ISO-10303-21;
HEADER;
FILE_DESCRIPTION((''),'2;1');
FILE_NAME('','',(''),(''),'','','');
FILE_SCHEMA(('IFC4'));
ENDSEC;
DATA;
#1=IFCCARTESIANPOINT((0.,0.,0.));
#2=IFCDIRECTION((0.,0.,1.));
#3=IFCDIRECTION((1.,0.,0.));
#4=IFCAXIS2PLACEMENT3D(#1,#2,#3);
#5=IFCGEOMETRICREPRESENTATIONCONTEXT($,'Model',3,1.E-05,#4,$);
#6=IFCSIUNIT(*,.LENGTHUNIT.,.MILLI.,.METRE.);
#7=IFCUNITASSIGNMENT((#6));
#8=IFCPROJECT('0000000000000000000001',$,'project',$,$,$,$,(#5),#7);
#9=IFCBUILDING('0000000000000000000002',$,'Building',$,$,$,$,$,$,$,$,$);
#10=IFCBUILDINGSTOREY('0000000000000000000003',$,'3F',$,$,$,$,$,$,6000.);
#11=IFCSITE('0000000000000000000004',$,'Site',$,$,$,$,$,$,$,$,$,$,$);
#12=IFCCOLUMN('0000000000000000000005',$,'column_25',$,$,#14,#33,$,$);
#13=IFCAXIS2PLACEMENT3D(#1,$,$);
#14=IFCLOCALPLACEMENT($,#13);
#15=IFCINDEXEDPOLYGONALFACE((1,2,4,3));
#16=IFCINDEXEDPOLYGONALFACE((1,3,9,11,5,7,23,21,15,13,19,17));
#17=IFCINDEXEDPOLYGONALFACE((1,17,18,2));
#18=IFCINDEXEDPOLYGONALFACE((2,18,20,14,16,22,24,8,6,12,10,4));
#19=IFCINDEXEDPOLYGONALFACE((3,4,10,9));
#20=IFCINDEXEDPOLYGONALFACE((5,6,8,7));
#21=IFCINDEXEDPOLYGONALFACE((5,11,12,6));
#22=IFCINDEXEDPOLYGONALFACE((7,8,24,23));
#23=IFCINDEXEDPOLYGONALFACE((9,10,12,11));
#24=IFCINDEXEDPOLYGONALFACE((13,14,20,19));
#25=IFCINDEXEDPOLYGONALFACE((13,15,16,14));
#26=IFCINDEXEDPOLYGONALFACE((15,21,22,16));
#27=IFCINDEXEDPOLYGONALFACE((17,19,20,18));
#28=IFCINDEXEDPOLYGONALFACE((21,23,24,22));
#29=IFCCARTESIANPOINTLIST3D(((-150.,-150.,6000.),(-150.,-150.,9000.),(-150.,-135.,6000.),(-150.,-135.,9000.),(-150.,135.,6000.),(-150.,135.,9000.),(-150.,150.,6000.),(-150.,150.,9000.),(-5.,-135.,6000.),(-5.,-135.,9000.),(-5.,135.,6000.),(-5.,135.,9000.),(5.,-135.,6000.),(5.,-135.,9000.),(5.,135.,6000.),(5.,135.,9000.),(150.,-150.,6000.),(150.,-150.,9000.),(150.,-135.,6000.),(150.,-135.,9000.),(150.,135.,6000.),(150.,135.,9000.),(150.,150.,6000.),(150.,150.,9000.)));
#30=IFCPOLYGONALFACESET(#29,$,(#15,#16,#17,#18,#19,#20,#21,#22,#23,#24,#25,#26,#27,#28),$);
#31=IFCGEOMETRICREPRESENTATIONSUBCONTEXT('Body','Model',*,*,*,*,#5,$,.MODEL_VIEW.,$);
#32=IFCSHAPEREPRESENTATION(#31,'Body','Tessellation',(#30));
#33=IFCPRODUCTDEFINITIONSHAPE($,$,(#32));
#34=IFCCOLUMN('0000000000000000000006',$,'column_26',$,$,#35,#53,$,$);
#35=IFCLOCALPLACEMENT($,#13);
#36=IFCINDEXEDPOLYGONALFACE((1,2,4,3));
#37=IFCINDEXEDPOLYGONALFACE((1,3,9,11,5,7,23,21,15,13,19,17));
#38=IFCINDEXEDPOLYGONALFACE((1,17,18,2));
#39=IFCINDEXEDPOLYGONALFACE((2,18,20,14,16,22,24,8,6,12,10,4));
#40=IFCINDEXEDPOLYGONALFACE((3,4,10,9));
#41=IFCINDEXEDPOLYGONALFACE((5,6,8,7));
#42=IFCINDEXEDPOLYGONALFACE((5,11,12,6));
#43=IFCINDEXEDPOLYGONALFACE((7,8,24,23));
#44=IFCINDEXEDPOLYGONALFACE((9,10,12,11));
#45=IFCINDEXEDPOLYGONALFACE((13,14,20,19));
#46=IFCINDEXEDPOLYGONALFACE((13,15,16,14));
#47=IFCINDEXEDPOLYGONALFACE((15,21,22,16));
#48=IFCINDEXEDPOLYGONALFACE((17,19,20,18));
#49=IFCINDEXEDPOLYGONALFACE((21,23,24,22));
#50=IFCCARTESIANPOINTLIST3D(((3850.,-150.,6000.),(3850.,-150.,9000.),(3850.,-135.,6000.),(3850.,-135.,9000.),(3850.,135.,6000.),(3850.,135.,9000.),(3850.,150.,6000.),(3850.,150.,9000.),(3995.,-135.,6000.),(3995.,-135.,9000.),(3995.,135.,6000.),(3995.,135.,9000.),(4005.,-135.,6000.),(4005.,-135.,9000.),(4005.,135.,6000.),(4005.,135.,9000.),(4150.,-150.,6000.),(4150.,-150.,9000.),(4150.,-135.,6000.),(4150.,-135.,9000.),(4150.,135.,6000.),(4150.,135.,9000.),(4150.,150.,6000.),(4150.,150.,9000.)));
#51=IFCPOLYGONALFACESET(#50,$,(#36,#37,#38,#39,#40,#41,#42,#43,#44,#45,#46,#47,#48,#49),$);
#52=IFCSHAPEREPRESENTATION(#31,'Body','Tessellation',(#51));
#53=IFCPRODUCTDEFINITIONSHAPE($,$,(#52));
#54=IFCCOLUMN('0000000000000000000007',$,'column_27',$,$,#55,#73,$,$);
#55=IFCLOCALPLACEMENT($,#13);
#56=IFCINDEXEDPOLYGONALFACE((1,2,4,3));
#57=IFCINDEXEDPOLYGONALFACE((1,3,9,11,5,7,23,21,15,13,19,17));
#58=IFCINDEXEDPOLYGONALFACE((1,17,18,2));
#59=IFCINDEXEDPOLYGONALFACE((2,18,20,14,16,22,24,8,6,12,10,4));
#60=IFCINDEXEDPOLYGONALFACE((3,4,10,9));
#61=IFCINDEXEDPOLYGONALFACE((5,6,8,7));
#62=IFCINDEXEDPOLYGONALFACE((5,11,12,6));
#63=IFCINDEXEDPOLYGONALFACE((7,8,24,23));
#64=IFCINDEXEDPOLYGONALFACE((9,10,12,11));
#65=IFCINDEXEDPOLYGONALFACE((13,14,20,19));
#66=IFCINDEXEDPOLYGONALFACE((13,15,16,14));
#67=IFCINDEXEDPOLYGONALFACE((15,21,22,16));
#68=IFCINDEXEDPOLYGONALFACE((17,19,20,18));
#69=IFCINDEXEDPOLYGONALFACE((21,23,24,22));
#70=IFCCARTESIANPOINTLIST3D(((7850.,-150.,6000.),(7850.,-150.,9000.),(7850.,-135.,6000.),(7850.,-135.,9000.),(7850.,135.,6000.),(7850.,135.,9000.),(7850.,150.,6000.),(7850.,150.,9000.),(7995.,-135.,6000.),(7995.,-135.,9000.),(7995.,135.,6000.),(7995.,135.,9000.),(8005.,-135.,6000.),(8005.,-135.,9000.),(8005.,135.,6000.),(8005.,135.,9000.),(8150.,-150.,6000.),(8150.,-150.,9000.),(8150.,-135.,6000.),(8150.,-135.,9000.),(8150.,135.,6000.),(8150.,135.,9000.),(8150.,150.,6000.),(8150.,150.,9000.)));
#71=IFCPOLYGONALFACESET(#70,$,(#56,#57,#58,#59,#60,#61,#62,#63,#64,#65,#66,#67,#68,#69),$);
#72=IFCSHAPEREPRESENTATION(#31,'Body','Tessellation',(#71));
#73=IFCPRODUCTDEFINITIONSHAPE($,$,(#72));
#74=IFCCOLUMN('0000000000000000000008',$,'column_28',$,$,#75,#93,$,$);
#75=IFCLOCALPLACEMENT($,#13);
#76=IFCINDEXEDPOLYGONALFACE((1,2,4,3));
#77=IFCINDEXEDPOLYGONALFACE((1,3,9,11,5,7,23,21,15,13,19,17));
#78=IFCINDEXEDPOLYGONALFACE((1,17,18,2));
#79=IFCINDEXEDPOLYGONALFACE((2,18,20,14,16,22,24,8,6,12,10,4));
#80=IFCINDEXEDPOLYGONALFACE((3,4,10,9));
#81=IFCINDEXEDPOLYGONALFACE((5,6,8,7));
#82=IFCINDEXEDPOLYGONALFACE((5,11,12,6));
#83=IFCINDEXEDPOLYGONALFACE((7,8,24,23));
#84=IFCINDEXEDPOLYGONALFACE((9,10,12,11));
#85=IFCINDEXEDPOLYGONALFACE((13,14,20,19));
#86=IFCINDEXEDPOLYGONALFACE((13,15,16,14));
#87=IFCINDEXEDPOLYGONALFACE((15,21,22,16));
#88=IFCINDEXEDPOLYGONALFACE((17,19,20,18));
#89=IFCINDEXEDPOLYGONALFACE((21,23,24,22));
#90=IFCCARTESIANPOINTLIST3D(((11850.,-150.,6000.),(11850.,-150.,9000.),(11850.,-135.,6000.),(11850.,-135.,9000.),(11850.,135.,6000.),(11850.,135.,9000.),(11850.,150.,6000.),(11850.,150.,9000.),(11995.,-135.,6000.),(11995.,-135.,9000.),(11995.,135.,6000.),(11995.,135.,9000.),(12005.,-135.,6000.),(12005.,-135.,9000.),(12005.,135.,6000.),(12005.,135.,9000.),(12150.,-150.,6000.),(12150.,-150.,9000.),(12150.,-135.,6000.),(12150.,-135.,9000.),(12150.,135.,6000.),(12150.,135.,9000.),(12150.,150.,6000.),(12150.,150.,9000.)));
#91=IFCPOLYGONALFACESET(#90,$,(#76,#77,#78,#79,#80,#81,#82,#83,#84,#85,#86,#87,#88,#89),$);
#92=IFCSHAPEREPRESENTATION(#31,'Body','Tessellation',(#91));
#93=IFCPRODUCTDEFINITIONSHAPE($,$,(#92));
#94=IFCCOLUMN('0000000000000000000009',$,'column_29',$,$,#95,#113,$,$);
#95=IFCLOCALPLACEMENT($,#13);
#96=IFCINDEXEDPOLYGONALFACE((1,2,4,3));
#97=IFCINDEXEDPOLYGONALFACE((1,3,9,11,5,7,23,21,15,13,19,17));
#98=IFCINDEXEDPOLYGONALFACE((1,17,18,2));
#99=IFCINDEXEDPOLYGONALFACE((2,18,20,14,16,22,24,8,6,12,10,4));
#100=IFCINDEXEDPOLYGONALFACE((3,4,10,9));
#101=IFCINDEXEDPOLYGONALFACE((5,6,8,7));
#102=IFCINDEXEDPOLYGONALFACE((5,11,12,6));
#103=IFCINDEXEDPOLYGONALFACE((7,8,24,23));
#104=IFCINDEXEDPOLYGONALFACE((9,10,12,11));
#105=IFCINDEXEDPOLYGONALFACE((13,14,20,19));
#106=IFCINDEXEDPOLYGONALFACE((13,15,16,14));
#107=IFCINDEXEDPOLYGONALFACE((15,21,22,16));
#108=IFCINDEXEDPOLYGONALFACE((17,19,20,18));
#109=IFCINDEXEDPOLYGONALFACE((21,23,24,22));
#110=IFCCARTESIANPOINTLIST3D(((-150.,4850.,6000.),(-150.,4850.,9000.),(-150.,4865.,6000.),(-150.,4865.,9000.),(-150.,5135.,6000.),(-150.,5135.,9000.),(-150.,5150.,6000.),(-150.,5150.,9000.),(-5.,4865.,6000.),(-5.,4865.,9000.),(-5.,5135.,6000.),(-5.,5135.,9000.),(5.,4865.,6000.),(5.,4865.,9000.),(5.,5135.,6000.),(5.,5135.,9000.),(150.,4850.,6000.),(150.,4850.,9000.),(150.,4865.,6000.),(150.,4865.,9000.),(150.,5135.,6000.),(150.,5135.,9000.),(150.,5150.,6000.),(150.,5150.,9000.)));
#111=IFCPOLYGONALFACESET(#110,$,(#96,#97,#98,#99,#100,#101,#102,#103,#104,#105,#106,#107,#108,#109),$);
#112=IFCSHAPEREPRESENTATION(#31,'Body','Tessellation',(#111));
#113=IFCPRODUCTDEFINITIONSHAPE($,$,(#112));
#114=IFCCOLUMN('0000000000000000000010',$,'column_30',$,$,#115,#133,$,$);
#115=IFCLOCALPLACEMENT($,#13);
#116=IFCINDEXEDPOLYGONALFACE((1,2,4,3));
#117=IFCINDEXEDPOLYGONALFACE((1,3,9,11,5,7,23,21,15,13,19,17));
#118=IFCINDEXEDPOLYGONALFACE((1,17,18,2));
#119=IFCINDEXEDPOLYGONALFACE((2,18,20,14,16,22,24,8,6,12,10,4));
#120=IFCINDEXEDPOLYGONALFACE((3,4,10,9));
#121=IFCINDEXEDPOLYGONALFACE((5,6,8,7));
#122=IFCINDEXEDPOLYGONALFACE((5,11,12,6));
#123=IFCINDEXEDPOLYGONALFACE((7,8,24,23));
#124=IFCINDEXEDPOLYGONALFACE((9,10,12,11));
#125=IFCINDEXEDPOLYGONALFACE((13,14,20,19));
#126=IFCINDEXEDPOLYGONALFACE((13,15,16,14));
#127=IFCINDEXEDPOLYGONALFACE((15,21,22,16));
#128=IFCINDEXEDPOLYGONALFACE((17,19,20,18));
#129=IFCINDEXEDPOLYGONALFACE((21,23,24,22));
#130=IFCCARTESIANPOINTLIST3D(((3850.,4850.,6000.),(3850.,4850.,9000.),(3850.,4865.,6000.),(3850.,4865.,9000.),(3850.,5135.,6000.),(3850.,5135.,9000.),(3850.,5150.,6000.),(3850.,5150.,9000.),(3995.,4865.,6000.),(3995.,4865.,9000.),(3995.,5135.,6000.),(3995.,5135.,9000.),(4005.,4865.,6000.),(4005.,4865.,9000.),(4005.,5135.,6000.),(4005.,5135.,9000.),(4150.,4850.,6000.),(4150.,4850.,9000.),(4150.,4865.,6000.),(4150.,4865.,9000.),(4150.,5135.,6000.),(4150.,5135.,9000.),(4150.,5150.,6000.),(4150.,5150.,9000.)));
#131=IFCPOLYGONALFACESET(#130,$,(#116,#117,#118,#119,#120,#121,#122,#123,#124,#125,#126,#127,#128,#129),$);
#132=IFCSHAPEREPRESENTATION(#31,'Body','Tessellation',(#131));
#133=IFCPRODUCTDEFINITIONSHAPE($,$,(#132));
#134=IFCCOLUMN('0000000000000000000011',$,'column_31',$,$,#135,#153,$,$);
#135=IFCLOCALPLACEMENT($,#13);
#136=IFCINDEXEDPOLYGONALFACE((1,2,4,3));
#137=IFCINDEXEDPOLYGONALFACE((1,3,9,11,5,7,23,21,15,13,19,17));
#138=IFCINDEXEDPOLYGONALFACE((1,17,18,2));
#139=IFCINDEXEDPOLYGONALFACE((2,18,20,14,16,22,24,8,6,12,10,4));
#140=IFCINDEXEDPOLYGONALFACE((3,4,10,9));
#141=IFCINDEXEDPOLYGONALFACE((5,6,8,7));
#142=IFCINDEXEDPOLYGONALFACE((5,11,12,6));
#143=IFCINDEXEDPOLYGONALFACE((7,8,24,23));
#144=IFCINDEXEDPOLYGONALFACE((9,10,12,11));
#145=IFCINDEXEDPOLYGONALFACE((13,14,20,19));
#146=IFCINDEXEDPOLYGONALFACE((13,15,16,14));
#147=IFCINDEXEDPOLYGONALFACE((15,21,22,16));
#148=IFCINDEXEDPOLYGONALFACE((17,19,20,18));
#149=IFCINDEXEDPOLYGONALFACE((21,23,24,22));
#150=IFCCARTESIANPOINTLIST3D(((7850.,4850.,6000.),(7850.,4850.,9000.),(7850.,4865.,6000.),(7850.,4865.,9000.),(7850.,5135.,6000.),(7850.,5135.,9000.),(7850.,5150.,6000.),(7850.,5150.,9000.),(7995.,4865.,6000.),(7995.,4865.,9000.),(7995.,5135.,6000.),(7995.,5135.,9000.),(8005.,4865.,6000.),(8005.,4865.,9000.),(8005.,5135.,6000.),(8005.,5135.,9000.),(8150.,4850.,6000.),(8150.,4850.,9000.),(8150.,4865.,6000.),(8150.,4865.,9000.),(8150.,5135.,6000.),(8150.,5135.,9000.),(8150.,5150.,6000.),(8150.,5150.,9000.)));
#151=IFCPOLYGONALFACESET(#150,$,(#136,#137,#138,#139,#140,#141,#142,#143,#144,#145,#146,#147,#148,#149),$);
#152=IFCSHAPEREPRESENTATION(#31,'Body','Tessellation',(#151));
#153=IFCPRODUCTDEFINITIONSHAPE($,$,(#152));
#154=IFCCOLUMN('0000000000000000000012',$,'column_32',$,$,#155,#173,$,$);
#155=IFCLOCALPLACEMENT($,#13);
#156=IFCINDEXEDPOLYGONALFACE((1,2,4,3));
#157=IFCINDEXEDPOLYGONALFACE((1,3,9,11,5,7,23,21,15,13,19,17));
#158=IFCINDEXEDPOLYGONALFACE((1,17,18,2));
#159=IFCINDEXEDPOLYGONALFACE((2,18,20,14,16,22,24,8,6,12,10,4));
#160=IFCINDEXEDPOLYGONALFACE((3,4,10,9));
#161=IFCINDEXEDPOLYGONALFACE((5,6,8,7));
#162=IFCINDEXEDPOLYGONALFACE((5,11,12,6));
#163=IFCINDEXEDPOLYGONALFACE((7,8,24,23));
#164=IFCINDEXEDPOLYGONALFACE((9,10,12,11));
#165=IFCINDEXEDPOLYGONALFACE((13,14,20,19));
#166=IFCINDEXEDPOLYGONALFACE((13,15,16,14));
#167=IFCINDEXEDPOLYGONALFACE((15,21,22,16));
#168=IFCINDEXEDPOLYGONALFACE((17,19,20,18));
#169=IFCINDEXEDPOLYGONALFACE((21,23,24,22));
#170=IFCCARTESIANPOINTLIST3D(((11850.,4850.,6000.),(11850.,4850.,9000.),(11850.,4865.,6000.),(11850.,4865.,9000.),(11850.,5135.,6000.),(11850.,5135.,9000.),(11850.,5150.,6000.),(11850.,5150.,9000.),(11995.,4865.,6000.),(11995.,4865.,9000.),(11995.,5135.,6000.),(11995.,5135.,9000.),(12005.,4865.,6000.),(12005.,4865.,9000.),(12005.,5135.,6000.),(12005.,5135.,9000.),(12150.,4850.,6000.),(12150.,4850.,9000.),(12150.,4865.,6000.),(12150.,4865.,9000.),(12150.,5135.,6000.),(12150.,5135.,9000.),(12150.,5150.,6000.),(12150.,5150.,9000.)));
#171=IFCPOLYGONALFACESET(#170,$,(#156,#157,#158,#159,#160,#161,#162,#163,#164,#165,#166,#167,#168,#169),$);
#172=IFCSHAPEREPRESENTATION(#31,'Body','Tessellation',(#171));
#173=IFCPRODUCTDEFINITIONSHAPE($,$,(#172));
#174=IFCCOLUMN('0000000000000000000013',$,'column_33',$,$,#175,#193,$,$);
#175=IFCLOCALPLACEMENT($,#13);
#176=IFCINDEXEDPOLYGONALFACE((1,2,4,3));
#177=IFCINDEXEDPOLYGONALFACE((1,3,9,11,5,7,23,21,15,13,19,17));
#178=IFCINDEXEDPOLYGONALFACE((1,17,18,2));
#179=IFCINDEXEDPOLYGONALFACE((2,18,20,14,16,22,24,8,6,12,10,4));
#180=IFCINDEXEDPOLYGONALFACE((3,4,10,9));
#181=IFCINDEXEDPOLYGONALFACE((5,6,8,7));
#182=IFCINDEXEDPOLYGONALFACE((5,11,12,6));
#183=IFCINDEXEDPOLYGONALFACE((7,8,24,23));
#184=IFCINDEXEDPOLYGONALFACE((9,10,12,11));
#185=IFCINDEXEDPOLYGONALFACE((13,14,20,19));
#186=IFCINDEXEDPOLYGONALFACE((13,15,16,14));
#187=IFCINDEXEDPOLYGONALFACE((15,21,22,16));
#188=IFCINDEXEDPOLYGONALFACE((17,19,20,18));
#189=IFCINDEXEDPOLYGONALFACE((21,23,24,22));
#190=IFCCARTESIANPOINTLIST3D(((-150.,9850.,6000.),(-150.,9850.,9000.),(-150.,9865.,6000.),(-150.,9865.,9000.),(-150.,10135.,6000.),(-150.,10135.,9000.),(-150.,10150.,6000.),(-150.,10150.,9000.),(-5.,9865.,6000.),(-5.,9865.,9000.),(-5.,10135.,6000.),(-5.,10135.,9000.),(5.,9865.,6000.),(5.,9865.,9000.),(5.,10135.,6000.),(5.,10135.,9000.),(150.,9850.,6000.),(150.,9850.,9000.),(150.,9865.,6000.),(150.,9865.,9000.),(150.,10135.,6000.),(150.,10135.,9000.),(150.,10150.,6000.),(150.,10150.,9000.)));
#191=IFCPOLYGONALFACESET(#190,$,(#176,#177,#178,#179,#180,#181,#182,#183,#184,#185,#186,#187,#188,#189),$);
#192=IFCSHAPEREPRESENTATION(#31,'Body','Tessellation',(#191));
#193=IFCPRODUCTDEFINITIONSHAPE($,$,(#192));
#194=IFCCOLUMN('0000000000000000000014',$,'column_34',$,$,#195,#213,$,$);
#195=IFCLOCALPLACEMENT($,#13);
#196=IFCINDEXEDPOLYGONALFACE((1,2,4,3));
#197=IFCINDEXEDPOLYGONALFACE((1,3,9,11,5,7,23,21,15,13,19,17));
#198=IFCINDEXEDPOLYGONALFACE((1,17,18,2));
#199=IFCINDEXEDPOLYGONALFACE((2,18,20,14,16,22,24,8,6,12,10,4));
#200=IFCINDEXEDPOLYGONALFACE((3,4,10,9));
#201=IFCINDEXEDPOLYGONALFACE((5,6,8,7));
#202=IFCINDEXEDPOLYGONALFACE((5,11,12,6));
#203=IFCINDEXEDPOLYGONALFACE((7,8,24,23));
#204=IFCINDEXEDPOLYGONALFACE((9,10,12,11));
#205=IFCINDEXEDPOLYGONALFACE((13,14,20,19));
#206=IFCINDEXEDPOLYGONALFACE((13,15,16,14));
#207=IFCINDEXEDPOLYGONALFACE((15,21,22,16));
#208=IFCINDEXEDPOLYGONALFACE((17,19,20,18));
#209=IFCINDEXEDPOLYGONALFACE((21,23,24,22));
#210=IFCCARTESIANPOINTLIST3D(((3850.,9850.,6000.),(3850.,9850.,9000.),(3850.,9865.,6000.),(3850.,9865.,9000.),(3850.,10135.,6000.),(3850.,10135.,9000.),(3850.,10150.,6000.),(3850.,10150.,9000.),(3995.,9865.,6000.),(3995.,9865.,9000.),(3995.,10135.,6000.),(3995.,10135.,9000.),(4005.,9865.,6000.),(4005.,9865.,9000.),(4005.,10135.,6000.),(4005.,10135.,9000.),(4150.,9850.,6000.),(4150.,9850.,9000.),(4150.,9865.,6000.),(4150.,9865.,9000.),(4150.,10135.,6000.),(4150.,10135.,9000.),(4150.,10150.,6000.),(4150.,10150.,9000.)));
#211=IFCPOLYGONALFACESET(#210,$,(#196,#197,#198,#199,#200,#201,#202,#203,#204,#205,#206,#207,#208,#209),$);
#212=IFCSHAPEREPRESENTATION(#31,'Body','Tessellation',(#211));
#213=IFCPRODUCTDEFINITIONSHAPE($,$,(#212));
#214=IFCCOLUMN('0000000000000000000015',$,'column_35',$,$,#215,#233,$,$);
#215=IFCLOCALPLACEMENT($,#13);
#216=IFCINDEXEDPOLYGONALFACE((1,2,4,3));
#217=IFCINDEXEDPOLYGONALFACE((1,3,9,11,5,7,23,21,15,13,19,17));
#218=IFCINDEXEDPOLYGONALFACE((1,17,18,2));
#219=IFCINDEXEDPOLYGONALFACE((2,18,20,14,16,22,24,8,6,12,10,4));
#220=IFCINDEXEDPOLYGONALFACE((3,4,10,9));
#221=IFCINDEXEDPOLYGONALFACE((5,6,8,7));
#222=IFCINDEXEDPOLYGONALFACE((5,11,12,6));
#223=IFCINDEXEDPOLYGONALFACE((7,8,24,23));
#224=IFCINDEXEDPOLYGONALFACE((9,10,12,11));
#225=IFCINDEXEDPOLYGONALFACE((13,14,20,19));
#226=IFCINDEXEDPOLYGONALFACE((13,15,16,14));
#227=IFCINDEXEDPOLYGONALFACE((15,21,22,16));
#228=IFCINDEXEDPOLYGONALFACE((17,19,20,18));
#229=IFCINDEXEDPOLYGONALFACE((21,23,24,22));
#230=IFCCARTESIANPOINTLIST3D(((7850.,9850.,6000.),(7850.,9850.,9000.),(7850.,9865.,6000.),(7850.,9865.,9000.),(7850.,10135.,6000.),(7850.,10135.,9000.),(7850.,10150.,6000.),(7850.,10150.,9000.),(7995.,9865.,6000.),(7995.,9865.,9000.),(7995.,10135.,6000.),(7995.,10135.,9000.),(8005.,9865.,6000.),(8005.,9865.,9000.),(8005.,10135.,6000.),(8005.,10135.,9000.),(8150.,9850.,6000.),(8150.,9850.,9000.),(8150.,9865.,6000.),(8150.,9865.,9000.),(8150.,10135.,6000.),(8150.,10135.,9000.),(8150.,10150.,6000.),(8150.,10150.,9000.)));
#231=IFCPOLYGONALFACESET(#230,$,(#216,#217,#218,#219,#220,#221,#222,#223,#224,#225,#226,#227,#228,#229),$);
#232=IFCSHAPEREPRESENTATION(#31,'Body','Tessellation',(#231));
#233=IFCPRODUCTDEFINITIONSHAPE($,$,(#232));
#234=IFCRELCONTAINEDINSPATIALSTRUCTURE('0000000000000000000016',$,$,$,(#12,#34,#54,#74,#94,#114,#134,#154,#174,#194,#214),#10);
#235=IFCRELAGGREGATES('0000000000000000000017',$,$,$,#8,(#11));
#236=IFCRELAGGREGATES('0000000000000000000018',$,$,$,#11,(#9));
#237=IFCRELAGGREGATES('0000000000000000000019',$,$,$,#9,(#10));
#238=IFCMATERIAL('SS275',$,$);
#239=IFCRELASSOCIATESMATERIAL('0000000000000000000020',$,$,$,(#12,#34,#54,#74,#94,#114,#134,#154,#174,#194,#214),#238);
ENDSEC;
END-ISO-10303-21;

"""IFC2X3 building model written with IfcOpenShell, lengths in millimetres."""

from ifc_helpers import new_model, si_unit, frame, origin, origin_with_axes, origin_2d_with_axis, place, context, subcontext, project, spatial, i_section, extrude, material, element, save


model = new_model("IFC2X3")

# Units and contexts
model_context = context("Model", 3, precision=1e-05, world=origin_with_axes())
body_context = subcontext(model_context, "Body", "Model", "MODEL_VIEW")
ifc_project = project(units=[si_unit("LENGTHUNIT", "METRE", prefix="MILLI")], contexts=[model_context])

# Site, building, storey
site = spatial("IfcSite", under=ifc_project, Name="Site")
building = spatial("IfcBuilding", under=site, Name="Building")
storey = spatial("IfcBuildingStorey", under=building, Name="3F", Elevation=6000.0)

# Columns
ifc_material = material(Name="SS275")
for number, where, z_axis, x_axis, name in (
    (1, (0.0, 0.0, 6000.0), (0.0, 0.0, 1.0), (1.0, 0.0, 0.0), "column_25"),
    (2, (4000.0, 0.0, 6000.0), (0.0, 0.0, 1.0), (1.0, 0.0, 0.0), "column_26"),
    (3, (8000.0, 0.0, 6000.0), (0.0, 0.0, 1.0), (1.0, 0.0, 0.0), "column_27"),
    (4, (12000.0, 0.0, 6000.0), (0.0, 0.0, 1.0), (1.0, 0.0, 0.0), "column_28"),
    (5, (0.0, 5000.0, 6000.0), (0.0, 0.0, 1.0), (1.0, 0.0, 0.0), "column_29"),
    (6, (4000.0, 5000.0, 6000.0), (0.0, 0.0, 1.0), (1.0, 0.0, 0.0), "column_30"),
    (7, (8000.0, 5000.0, 6000.0), (0.0, 0.0, 1.0), (1.0, 0.0, 0.0), "column_31"),
    (8, (12000.0, 5000.0, 6000.0), (0.0, 0.0, 1.0), (1.0, 0.0, 0.0), "column_32"),
    (9, (0.0, 10000.0, 6000.0), (0.0, 0.0, 1.0), (1.0, 0.0, 0.0), "column_33"),
    (10, (4000.0, 10000.0, 6000.0), (0.0, 0.0, 1.0), (1.0, 0.0, 0.0), "column_34"),
    (11, (8000.0, 10000.0, 6000.0), (0.0, 0.0, 1.0), (1.0, 0.0, 0.0), "column_35"),
):
    element("IfcColumn", number, at=place(None, frame(where, z_axis=z_axis, x_axis=x_axis)), inside=storey, material=ifc_material, Name=name, context=body_context, shape_type="SweptSolid", body=[
        extrude(i_section(OverallWidth=300.0, OverallDepth=300.0, WebThickness=10.0, FlangeThickness=15.0, at=origin_2d_with_axis()), origin(), (0.0, 0.0, 1.0), 3000.0),
    ])

save(model, "model.ifc")
